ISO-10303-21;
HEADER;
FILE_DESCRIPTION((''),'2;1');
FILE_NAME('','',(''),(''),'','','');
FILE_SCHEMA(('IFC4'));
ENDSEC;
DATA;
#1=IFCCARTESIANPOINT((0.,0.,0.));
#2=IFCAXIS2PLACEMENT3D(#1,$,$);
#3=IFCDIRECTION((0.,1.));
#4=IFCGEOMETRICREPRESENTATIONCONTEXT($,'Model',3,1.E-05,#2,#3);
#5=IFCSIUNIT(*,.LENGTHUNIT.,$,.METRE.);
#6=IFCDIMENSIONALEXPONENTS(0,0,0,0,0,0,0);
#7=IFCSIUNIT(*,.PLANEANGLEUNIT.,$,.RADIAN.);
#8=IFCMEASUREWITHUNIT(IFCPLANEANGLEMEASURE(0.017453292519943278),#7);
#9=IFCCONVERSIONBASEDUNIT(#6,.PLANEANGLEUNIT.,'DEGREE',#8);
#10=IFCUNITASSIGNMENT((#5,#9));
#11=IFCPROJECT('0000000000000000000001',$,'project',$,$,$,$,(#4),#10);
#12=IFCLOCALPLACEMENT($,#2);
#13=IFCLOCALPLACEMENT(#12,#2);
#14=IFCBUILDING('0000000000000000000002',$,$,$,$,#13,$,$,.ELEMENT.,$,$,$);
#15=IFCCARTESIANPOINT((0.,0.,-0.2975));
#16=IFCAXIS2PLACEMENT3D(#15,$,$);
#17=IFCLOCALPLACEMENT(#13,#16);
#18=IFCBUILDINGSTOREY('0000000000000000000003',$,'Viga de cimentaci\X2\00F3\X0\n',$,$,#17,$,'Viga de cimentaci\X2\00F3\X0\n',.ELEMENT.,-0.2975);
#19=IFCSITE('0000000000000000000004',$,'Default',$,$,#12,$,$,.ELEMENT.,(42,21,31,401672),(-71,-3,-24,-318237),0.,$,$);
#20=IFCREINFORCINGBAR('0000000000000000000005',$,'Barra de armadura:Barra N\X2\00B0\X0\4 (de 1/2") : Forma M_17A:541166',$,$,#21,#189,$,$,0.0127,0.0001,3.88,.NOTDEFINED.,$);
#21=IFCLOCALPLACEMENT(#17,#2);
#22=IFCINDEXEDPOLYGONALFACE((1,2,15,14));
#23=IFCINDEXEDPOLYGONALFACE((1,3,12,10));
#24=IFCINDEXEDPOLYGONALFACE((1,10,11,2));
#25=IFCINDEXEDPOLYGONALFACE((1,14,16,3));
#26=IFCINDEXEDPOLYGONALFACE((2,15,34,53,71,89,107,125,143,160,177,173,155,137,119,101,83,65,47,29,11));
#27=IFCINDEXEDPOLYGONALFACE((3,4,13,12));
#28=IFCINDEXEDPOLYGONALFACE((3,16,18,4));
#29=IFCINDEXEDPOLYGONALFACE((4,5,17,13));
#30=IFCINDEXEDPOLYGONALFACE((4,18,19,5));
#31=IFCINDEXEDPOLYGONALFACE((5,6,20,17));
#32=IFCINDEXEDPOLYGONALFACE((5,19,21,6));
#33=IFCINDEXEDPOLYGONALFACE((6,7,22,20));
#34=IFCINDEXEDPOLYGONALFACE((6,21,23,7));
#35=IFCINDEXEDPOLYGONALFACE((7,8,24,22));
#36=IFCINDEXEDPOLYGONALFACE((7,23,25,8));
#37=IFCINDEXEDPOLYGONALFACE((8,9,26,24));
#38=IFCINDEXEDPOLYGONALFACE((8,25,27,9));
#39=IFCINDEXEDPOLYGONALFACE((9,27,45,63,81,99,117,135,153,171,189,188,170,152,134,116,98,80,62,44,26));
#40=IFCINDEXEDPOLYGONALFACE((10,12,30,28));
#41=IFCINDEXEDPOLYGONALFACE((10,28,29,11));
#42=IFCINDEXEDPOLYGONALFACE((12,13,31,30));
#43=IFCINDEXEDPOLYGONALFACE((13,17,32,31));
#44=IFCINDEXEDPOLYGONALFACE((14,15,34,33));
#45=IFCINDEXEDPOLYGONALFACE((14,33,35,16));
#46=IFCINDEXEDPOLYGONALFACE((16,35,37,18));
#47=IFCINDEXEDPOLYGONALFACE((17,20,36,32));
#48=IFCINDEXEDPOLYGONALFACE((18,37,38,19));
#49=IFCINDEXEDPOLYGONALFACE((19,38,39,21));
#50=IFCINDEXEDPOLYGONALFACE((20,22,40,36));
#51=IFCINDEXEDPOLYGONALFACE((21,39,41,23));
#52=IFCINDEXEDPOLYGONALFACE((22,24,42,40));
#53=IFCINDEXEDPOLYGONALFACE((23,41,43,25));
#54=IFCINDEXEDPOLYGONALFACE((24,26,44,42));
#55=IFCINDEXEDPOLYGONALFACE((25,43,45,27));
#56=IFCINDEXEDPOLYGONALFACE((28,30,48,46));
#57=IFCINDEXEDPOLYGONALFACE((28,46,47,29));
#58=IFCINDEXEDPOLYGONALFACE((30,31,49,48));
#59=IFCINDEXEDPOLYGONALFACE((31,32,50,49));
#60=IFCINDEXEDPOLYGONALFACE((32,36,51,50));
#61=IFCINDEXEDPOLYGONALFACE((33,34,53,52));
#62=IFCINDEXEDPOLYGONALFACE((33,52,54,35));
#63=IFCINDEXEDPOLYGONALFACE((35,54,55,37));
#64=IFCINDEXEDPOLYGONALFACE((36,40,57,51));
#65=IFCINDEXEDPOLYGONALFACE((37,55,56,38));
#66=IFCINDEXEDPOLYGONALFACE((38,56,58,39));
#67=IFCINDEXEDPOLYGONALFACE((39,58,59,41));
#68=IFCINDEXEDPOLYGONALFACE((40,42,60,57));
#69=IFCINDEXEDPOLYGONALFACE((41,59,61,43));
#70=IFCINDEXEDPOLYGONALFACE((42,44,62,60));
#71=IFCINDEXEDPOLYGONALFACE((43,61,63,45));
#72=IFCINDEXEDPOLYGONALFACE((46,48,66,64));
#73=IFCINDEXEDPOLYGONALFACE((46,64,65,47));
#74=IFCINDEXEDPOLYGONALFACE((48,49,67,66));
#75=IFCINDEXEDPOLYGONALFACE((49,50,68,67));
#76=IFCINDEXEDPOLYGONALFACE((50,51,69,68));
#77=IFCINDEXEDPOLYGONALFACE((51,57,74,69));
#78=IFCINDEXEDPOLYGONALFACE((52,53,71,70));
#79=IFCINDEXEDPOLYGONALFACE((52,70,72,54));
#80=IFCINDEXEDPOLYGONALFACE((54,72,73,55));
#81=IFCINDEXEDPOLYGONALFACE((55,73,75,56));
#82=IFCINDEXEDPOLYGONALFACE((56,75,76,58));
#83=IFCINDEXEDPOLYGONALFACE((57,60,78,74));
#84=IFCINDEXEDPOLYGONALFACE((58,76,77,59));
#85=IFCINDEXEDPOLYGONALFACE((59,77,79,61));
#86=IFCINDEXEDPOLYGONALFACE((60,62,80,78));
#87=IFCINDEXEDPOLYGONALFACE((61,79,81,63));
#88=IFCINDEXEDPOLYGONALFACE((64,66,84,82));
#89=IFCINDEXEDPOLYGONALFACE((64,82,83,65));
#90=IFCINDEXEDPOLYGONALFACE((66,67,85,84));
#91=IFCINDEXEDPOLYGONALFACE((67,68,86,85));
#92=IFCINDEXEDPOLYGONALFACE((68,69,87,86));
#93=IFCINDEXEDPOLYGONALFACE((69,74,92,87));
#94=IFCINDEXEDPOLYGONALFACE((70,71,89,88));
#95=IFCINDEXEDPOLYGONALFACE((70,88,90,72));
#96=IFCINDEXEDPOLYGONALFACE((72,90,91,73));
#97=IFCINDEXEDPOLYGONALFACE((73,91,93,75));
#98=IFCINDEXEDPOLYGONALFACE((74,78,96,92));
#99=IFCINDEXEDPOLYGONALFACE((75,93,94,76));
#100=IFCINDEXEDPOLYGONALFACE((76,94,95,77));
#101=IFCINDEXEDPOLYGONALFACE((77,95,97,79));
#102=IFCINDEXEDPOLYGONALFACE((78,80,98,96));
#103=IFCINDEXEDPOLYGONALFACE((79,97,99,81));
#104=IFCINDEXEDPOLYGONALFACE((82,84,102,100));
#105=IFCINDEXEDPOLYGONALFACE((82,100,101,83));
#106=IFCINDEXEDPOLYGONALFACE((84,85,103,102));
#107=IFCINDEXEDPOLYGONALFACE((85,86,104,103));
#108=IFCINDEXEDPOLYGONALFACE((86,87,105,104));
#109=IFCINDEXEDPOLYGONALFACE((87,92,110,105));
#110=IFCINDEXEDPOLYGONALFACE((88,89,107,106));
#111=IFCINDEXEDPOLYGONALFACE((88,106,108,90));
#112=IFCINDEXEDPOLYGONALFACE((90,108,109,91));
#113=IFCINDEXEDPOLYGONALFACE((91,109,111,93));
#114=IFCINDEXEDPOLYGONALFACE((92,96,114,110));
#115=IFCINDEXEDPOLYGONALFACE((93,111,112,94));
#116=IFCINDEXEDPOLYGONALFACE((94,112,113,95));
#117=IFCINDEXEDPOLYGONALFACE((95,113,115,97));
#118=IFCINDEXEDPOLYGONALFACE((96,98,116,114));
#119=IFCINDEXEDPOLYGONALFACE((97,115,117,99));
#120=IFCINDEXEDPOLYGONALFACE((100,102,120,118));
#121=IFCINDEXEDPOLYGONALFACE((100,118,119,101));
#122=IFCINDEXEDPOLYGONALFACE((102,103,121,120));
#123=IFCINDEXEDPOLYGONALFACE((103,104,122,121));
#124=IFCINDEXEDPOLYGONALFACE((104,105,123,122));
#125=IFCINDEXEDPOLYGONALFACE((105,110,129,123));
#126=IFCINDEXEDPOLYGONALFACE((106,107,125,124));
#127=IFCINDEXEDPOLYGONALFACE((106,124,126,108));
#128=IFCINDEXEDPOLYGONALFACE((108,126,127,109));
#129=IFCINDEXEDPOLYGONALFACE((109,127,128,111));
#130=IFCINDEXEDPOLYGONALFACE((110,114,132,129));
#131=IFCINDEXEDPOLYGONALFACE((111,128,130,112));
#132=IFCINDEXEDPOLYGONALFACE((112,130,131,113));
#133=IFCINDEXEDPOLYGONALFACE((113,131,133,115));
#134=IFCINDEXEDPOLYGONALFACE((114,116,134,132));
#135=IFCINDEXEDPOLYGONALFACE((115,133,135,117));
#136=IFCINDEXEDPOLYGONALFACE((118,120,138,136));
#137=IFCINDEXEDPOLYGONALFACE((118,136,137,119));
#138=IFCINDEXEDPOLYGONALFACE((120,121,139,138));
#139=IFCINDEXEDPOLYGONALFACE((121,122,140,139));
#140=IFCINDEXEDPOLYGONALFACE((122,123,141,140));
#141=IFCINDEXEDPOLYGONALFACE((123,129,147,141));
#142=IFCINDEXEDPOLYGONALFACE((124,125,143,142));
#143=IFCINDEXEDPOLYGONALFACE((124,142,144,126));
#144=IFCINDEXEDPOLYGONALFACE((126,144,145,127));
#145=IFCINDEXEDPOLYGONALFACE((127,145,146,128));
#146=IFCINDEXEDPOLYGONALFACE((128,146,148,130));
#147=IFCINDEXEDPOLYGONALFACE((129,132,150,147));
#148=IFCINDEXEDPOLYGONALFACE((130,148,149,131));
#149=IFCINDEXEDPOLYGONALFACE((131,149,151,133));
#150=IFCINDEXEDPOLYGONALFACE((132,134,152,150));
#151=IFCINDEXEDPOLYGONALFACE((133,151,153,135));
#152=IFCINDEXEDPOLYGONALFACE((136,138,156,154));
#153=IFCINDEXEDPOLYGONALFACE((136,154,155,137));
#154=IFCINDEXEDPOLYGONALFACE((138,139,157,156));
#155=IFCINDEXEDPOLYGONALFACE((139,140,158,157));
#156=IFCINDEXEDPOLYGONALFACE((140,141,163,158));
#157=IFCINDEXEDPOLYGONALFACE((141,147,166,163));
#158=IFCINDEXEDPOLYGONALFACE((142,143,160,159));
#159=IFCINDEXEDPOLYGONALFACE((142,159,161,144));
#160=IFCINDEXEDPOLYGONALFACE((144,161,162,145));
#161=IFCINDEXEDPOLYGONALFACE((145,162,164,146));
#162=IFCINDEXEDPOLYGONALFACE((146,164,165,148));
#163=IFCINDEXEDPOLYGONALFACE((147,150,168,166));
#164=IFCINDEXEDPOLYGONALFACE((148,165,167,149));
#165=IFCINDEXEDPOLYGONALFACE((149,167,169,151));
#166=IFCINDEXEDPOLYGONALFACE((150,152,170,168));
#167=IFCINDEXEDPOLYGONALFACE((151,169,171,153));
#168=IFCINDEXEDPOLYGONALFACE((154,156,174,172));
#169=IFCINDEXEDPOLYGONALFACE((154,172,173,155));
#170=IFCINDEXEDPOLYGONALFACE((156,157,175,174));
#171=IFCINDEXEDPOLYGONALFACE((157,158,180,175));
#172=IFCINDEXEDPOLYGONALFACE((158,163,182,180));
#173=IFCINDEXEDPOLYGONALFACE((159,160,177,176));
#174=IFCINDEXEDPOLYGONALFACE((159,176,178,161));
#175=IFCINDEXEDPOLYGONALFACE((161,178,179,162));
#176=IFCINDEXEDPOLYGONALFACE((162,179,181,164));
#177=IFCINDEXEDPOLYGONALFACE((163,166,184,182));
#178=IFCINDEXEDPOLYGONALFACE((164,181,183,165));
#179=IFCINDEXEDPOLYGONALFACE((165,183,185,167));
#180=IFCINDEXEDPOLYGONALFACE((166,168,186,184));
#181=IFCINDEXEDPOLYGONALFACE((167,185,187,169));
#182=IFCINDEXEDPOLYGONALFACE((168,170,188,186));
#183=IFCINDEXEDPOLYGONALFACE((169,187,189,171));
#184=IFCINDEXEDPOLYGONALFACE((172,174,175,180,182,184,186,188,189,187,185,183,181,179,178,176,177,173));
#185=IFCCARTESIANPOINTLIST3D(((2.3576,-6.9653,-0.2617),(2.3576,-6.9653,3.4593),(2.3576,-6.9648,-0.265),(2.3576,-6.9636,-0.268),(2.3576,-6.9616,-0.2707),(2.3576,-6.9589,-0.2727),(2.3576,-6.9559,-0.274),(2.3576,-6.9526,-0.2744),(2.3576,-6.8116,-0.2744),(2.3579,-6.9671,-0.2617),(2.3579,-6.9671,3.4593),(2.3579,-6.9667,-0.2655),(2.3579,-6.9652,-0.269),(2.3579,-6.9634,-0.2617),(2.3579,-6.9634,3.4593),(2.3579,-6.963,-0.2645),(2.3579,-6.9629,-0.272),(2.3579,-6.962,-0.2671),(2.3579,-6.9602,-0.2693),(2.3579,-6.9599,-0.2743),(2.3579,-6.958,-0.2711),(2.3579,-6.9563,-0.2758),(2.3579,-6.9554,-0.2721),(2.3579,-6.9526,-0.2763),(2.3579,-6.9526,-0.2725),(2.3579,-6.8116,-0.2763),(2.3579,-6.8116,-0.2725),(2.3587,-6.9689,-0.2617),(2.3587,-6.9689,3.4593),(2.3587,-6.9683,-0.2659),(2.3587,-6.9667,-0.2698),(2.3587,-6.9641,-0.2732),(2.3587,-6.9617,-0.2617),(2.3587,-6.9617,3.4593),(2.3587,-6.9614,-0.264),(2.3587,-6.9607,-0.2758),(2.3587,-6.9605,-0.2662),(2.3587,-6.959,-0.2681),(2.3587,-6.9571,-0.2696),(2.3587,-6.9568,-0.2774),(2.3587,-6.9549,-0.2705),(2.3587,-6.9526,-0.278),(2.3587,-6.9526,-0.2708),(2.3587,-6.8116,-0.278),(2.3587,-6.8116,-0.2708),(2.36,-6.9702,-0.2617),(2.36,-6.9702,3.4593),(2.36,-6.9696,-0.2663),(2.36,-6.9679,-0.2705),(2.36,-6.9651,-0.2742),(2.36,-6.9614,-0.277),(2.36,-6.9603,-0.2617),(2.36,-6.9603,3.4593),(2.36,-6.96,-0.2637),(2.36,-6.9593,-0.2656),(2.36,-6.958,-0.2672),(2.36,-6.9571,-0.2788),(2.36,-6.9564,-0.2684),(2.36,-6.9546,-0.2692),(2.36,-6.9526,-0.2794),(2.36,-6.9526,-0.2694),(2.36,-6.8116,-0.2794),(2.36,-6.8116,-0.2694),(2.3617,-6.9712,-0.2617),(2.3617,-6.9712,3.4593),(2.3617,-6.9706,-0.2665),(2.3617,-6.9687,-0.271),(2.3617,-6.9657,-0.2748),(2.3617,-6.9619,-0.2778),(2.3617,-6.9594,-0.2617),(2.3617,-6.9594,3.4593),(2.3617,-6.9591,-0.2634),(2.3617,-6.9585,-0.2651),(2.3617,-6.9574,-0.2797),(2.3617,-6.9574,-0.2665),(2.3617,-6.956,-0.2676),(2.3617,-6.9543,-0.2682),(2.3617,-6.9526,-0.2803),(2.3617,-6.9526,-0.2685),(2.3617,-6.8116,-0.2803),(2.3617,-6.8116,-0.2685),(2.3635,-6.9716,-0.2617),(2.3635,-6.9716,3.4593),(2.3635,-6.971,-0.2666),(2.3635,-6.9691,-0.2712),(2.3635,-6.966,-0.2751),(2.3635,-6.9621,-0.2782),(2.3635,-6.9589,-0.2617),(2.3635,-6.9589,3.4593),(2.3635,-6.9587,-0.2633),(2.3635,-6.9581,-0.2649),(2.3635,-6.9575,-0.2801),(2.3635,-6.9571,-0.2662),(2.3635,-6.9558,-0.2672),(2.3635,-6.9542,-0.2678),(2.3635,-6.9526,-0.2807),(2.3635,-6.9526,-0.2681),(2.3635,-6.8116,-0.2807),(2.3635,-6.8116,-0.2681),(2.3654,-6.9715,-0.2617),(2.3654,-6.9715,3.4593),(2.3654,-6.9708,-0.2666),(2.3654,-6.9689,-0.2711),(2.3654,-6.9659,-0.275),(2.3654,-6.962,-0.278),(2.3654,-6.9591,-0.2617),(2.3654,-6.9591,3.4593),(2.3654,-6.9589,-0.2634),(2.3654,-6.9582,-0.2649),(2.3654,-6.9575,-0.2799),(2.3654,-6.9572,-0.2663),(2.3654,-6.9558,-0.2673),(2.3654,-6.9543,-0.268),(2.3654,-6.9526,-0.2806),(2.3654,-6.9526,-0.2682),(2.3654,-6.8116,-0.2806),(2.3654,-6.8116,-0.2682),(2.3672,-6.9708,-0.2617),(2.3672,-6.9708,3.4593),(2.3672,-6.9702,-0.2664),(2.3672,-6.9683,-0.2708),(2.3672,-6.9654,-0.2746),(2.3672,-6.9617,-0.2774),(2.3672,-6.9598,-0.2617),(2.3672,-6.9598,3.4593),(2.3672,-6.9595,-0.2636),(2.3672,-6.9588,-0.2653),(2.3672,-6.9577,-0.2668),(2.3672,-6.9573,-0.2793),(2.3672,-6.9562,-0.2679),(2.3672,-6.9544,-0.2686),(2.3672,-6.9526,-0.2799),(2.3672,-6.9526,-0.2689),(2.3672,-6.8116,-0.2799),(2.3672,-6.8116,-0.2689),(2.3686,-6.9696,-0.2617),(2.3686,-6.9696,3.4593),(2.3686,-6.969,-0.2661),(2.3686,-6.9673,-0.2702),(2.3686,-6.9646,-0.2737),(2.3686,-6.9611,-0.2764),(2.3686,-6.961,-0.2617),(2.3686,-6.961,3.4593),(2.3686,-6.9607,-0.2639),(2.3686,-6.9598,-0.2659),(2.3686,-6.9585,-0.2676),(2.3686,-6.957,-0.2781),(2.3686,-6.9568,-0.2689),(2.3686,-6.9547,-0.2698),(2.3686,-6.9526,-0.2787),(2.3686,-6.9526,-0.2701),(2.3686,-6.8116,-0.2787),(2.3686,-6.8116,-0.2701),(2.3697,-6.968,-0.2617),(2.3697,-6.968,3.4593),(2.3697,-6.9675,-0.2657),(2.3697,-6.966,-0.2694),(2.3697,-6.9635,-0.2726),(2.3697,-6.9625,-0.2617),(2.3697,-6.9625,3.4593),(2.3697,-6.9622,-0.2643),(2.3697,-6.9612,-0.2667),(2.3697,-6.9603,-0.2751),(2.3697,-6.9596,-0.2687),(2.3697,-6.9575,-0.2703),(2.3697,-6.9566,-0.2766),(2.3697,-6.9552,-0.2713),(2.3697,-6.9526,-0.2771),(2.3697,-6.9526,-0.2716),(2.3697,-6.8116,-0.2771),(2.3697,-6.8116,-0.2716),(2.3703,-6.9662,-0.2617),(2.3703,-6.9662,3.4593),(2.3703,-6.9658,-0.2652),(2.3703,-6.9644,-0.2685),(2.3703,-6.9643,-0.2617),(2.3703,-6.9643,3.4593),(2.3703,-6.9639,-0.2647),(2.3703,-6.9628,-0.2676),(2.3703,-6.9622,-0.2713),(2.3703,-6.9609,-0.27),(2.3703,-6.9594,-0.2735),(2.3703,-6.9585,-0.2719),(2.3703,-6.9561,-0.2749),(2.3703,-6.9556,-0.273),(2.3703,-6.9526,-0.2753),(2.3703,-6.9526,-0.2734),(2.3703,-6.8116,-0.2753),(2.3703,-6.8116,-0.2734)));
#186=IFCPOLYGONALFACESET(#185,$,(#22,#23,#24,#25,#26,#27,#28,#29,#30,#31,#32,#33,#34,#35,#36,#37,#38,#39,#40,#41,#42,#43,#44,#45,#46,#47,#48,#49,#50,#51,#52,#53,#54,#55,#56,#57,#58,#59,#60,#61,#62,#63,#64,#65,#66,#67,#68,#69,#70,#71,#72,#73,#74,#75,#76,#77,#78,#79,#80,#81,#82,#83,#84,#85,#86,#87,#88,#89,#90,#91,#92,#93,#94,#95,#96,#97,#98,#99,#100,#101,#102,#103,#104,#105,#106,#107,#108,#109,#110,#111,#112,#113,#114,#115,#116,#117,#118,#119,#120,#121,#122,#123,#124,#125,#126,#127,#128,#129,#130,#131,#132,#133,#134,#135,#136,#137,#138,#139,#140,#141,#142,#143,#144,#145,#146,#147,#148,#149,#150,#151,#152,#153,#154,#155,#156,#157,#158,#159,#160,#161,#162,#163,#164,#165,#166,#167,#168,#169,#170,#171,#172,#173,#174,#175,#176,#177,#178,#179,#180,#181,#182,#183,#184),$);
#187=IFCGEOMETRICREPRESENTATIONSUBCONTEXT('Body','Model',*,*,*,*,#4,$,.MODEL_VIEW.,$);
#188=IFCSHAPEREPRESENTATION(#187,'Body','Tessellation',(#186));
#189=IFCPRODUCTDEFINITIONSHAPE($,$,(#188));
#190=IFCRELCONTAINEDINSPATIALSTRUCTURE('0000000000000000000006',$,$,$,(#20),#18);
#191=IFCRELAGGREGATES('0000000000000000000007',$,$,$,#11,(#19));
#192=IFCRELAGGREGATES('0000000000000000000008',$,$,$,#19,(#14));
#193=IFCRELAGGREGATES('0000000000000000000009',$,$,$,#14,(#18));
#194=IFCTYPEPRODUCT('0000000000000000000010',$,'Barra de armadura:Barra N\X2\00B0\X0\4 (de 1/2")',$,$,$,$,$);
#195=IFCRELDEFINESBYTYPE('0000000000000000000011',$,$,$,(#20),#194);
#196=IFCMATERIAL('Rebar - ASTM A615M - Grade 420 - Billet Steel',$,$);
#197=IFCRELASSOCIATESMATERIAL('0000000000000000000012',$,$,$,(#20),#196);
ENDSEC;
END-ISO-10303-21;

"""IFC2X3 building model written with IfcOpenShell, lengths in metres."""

from ifc_helpers import new_model, entity, si_unit, converted_unit, direction, frame, origin, place, context, subcontext, project, spatial, material, type_object, element, save


model = new_model("IFC2X3")

# Units and contexts
model_context = context("Model", 3, precision=1e-05, world=origin(), true_north=direction((0.0, 1.0)))
body_context = subcontext(model_context, "Body", "Model", "MODEL_VIEW")
ifc_project = project(units=[si_unit("LENGTHUNIT", "METRE"), converted_unit("PLANEANGLEUNIT", "DEGREE", entity("IfcPlaneAngleMeasure", 0.017453292519943278), si_unit("PLANEANGLEUNIT", "RADIAN"), dimensions=[0, 0, 0, 0, 0, 0, 0])], contexts=[model_context])

# Site, building, storey
site_placement = place(None, origin())
site = spatial("IfcSite", under=ifc_project, at=site_placement, Name="Default", CompositionType="ELEMENT", RefLatitude=(42, 21, 31, 401672), RefLongitude=(-71, -3, -24, -318237), RefElevation=0.0)
building_placement = place(site_placement, origin())
building = spatial("IfcBuilding", under=site, at=building_placement, CompositionType="ELEMENT")
storey_placement = place(building_placement, frame((0.0, 0.0, -0.2975)))
storey = spatial("IfcBuildingStorey", under=building, at=storey_placement, Name="Viga de cimentación", LongName="Viga de cimentación", CompositionType="ELEMENT", Elevation=-0.2975)

# Reinforcing bar
ifc_material_1 = material(Name="Rebar - ASTM A615M - Grade 420 - Billet Steel")
type_product_1 = type_object("IfcTypeProduct", Name="Barra de armadura:Barra N°4 (de 1/2\")")
reinforcing_bar_1_placement = place(storey_placement, origin())
element("IfcReinforcingBar", 1, at=reinforcing_bar_1_placement, inside=storey, type_object=type_product_1, material=ifc_material_1, Name="Barra de armadura:Barra N°4 (de 1/2\") : Forma M_17A:541166", BarLength=3.88, BarRole="NOTDEFINED", CrossSectionArea=0.0001, NominalDiameter=0.0127, context=body_context, shape_type="AdvancedSweptSolid", body=[
    entity("IfcSweptDiskSolid", entity("IfcCompositeCurve", [entity("IfcCompositeCurveSegment", "CONTINUOUS", True, entity("IfcPolyline", [entity("IfcCartesianPoint", [2.364, -6.9653, 3.4593]), entity("IfcCartesianPoint", [2.364, -6.9653, -0.2617])])), entity("IfcCompositeCurveSegment", "CONTINUOUS", True, entity("IfcTrimmedCurve", entity("IfcCircle", entity("IfcAxis2Placement3D", entity("IfcCartesianPoint", [2.364, -6.9526, -0.2617]), entity("IfcDirection", [1.0, 0.0, 0.0]), entity("IfcDirection", [0.0, 0.0, -1.0])), 0.0127), [entity("IfcParameterValue", 270.0)], [entity("IfcParameterValue", 360.0)], True, "PARAMETER")), entity("IfcCompositeCurveSegment", "CONTINUOUS", True, entity("IfcPolyline", [entity("IfcCartesianPoint", [2.364, -6.9526, -0.2744]), entity("IfcCartesianPoint", [2.364, -6.8116, -0.2744])]))], False), 0.0063, None, 0.0, 92.0),
])

save(model, "model.ifc")
